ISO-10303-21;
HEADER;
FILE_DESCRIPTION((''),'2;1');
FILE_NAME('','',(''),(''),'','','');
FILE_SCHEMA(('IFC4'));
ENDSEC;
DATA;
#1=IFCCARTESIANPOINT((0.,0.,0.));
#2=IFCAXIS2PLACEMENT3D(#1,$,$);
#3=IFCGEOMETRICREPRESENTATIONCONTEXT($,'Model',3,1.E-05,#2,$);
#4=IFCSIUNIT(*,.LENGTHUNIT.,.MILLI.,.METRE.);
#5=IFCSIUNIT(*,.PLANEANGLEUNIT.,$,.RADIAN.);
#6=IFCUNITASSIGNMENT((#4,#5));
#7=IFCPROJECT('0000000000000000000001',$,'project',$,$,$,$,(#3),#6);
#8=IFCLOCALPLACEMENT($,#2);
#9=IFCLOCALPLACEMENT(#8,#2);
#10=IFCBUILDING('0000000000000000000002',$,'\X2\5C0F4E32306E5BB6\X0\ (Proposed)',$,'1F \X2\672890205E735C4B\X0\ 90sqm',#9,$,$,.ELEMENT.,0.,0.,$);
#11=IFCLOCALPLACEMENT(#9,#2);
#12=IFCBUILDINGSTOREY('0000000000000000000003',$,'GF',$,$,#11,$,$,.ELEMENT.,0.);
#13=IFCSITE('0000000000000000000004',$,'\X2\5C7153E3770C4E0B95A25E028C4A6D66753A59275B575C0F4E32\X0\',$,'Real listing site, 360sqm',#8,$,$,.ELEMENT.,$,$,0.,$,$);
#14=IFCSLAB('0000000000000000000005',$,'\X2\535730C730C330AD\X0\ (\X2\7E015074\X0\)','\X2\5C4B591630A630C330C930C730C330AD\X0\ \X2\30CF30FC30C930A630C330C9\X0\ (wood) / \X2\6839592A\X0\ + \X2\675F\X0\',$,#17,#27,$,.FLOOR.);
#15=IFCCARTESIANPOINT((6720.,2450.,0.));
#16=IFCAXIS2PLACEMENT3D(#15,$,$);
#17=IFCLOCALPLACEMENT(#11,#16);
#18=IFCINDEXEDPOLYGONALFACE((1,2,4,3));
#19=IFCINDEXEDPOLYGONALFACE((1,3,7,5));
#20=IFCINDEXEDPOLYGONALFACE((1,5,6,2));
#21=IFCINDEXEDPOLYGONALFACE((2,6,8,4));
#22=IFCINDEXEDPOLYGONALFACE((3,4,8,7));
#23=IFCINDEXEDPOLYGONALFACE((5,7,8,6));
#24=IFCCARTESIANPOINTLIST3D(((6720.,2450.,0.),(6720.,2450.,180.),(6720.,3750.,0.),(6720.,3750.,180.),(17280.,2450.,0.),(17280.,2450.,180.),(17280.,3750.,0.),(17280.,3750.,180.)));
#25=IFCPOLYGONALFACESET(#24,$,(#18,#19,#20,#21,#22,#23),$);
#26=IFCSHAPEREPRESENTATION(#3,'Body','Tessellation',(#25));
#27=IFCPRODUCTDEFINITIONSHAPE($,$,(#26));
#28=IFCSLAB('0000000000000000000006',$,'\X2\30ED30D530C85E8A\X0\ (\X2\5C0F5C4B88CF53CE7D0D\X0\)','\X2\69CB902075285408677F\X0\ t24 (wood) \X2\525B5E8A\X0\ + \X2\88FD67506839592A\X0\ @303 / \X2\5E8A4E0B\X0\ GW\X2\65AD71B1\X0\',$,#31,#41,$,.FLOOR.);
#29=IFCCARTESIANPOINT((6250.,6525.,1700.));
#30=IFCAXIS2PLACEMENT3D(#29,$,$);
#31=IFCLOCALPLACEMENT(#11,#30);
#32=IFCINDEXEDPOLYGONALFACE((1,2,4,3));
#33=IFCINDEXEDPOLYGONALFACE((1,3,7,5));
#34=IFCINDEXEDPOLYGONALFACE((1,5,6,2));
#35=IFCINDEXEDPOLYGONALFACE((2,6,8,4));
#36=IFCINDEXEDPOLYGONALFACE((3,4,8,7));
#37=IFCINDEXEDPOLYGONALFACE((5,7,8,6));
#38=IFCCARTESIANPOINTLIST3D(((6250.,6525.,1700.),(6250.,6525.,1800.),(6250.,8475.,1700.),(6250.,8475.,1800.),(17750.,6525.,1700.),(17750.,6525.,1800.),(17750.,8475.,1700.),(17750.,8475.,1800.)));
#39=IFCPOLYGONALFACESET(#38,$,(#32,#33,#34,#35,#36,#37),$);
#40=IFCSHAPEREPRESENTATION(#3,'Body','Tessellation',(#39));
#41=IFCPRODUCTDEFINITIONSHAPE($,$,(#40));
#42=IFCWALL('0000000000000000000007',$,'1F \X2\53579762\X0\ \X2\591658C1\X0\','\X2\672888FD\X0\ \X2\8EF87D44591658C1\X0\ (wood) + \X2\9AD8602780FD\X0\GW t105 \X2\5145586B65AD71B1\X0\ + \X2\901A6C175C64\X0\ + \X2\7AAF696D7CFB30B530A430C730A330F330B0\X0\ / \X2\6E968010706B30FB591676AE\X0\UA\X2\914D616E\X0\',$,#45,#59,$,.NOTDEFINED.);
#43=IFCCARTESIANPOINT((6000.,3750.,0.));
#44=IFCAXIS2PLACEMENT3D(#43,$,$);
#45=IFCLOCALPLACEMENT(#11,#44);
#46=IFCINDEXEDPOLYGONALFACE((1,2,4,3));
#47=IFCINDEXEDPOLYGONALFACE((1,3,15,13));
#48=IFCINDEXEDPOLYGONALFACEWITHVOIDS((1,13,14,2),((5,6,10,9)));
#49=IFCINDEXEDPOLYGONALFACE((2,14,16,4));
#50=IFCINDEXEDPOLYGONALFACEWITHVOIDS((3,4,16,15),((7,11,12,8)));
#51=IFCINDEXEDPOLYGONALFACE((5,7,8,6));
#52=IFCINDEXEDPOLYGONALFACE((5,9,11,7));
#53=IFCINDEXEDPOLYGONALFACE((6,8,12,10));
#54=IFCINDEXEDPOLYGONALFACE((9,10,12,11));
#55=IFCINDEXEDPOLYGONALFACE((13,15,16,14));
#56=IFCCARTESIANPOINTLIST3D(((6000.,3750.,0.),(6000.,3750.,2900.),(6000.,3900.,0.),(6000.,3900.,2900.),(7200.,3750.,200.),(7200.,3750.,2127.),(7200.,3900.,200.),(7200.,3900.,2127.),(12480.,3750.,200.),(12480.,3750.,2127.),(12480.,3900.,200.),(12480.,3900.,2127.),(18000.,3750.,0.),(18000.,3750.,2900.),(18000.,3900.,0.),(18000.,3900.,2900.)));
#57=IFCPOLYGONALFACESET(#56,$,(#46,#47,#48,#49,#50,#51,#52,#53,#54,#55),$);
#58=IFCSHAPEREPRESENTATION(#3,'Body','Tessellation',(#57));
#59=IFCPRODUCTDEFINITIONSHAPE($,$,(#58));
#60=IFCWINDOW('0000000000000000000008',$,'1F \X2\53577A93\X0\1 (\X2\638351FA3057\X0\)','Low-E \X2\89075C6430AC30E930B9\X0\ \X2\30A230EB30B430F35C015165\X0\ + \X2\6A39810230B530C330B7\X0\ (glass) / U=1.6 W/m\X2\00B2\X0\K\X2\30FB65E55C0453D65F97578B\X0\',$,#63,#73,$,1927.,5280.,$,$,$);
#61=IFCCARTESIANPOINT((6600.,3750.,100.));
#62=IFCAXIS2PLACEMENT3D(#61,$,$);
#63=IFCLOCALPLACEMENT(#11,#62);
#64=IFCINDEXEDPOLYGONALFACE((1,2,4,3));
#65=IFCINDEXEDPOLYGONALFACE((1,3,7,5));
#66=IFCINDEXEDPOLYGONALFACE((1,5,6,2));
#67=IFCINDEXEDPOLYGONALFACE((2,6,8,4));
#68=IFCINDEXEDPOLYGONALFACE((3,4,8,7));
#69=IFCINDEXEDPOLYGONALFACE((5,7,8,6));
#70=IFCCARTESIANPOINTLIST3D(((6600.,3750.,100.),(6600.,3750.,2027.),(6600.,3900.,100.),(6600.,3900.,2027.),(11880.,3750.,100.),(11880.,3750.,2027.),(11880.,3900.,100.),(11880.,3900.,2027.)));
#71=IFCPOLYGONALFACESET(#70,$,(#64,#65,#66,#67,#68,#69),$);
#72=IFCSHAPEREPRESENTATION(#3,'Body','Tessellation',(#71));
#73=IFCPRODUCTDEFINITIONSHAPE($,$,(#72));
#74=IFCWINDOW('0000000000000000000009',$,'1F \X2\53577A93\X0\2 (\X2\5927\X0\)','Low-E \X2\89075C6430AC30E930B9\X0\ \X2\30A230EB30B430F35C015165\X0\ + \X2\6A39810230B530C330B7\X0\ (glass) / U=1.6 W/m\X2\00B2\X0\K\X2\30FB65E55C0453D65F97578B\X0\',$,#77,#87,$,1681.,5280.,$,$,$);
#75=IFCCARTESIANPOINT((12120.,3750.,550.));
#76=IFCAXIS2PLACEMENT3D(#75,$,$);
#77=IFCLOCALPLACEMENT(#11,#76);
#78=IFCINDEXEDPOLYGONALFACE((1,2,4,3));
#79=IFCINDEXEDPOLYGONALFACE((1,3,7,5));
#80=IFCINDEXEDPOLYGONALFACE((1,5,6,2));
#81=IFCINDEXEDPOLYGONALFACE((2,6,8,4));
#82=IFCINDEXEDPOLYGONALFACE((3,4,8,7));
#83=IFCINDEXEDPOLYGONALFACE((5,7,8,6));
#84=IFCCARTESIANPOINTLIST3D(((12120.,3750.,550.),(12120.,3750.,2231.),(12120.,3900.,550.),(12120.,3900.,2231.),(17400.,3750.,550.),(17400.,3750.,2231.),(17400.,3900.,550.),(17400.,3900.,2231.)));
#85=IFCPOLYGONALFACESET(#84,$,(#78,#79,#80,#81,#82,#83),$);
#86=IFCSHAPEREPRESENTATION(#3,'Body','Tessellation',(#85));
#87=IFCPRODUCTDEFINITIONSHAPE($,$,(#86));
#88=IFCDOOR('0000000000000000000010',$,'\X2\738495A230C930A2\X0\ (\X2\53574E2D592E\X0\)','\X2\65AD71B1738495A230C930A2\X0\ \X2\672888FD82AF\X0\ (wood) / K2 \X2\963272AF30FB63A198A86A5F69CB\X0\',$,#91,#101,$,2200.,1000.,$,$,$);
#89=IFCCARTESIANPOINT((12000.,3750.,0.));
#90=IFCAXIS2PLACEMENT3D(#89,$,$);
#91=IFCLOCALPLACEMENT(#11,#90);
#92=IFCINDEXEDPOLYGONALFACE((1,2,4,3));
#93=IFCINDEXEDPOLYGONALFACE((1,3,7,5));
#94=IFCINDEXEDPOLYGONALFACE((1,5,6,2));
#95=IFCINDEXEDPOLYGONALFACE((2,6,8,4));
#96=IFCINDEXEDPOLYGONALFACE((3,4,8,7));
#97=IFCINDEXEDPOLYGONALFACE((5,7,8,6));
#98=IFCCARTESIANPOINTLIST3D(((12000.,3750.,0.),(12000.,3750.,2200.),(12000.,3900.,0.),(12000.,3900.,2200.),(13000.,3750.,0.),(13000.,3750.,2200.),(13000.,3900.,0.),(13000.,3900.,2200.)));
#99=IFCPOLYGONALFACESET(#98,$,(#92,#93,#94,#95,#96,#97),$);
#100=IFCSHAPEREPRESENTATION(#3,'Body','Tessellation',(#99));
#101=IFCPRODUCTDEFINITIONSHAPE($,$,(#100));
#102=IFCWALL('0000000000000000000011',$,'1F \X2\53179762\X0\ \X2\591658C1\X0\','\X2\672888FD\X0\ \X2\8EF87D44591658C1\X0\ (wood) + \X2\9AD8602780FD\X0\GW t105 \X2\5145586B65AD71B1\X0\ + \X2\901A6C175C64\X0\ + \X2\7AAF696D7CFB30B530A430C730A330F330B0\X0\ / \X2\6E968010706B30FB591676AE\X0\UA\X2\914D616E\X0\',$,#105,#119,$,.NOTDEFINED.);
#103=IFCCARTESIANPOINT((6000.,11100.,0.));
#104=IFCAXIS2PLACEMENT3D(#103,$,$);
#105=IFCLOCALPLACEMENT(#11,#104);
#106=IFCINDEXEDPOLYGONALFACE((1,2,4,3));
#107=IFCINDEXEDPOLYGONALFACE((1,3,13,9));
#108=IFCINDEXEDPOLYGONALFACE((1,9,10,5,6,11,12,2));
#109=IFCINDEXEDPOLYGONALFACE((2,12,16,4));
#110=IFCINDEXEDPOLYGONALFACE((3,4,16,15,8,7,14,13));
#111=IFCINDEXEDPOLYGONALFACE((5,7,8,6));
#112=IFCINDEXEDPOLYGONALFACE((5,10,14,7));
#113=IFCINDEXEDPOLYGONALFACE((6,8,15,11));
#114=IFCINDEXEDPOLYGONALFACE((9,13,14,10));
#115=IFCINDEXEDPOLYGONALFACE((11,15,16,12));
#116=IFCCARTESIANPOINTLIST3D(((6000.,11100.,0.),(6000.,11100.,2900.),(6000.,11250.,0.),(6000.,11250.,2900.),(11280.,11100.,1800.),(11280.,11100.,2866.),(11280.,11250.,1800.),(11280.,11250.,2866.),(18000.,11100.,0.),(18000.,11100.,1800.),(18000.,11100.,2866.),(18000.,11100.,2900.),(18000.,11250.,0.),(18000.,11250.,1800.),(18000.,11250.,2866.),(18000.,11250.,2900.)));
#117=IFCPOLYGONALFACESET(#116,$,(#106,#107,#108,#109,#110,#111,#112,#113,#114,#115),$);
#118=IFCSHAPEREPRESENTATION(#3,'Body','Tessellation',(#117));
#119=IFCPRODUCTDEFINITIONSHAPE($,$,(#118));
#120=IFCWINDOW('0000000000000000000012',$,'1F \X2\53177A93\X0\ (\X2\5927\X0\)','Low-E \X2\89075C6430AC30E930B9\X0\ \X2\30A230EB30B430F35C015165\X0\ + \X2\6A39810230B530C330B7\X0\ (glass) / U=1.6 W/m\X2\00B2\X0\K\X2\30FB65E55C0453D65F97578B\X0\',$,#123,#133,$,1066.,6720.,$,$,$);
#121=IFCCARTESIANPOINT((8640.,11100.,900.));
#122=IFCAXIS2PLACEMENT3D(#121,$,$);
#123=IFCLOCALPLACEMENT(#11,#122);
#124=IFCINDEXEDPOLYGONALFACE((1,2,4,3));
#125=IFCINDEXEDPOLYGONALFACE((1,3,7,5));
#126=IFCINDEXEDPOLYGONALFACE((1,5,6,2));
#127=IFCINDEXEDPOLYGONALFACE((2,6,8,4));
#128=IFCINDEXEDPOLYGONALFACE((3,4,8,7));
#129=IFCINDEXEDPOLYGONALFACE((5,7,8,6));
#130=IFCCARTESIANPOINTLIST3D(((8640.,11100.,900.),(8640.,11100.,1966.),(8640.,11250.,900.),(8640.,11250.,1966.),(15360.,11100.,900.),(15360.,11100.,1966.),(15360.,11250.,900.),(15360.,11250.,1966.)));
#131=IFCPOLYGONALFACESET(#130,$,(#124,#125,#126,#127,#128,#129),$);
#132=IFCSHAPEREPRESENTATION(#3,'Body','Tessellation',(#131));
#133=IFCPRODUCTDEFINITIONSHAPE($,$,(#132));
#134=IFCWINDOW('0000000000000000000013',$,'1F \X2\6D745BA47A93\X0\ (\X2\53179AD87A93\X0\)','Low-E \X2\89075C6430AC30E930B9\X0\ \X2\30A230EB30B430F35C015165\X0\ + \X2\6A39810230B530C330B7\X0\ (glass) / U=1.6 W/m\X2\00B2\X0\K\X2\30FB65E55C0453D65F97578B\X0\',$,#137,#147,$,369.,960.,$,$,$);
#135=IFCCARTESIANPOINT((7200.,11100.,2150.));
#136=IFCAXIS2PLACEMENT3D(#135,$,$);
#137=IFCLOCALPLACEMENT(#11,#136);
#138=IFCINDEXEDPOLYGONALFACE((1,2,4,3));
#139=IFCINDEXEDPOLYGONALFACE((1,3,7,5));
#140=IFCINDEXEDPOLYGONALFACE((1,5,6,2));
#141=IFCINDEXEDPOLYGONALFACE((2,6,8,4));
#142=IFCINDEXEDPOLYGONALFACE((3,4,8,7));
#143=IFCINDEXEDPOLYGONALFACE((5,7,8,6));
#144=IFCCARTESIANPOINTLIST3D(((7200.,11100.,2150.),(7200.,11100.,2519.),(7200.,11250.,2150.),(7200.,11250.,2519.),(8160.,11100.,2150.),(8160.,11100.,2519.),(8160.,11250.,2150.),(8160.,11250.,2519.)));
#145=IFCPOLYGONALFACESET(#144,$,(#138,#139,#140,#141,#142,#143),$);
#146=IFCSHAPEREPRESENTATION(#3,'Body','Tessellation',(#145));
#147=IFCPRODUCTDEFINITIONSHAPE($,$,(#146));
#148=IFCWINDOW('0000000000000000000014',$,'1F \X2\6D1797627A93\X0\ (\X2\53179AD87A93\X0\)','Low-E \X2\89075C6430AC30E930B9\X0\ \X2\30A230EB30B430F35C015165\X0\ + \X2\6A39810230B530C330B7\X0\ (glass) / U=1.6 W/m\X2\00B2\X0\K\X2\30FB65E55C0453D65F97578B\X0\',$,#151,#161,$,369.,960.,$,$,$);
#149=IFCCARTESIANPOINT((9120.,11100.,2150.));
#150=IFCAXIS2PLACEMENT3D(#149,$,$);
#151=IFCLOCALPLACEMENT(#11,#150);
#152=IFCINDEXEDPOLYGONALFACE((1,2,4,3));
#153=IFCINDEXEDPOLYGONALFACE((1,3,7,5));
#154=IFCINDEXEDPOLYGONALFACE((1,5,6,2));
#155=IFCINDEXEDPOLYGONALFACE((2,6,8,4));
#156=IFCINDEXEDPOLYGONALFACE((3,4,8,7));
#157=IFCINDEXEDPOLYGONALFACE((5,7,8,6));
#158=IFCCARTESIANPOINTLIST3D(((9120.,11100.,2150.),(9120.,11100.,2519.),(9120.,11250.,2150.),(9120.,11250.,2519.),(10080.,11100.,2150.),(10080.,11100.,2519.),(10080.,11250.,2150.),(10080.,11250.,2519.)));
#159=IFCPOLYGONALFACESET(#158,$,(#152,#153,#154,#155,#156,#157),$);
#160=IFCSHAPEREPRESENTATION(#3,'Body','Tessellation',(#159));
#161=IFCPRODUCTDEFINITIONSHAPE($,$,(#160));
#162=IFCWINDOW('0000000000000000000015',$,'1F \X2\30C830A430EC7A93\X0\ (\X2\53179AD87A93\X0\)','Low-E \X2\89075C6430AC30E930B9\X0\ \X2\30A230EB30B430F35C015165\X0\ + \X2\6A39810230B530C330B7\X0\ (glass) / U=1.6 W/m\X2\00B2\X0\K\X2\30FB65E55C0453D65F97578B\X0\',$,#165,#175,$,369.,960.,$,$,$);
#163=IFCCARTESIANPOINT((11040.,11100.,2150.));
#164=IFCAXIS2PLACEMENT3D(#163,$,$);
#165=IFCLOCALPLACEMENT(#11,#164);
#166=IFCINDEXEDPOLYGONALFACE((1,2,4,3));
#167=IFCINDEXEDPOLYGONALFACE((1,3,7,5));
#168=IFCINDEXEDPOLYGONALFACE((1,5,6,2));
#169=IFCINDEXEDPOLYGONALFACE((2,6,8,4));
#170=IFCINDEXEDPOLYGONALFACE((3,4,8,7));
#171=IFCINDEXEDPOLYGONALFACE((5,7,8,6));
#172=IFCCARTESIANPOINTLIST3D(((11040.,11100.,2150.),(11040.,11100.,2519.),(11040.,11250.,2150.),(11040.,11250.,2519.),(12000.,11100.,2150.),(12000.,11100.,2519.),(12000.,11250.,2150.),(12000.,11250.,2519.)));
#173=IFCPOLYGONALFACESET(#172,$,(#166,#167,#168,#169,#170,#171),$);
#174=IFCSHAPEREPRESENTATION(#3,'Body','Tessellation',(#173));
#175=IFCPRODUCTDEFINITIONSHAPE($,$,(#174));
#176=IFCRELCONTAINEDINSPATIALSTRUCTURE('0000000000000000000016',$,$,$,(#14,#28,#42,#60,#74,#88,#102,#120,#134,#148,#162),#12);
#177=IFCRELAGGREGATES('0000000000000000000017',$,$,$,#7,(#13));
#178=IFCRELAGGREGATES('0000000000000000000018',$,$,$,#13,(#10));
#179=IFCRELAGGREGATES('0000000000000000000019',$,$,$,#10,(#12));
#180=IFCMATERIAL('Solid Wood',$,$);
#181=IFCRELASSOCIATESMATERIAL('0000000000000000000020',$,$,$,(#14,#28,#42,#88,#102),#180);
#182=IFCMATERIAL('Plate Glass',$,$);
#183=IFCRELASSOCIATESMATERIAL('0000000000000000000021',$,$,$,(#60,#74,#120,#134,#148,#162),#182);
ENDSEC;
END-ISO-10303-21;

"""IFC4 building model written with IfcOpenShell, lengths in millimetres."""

from ifc_helpers import new_model, si_unit, frame, frame_2d, origin, place, context, project, spatial, rectangle, extrude, material, element, fill, save


model = new_model("IFC4")

# Units and contexts
model_context = context("Model", 3, precision=1e-05, world=origin())
ifc_project = project(units=[si_unit("LENGTHUNIT", "METRE", prefix="MILLI"), si_unit("PLANEANGLEUNIT", "RADIAN")], contexts=[model_context])

# Site, building, storey
site_placement = place(None, origin())
site = spatial("IfcSite", under=ifc_project, at=site_placement, Name="山口県下関市豊浦町大字小串", ObjectType="Real listing site, 360sqm", CompositionType="ELEMENT", RefElevation=0.0)
building_placement = place(site_placement, origin())
building = spatial("IfcBuilding", under=site, at=building_placement, Name="小串の家 (Proposed)", ObjectType="1F 木造平屋 90sqm", CompositionType="ELEMENT", ElevationOfRefHeight=0.0, ElevationOfTerrain=0.0)
storey_placement = place(building_placement, origin())
storey = spatial("IfcBuildingStorey", under=building, at=storey_placement, Name="GF", CompositionType="ELEMENT", Elevation=0.0)

# Slabs
ifc_material_1 = material(Name="Solid Wood")
slab_1_placement = place(storey_placement, frame((6720.0, 2450.0, 0.0)))
element("IfcSlab", 1, at=slab_1_placement, inside=storey, material=ifc_material_1, Name="南デッキ (縁側)", Description="屋外ウッドデッキ ハードウッド (wood) / 根太 + 束", PredefinedType="FLOOR", context=model_context, shape_type="SweptSolid", body=[
    extrude(rectangle(XDim=10560.0, YDim=1300.0, at=frame_2d((5280.0, 650.0))), frame((6720.0, 2450.0, 0.0)), (0.0, 0.0, 1.0), 180.0),
])
slab_2_placement = place(storey_placement, frame((6250.0, 6525.0, 1700.0)))
element("IfcSlab", 2, at=slab_2_placement, inside=storey, material=ifc_material_1, Name="ロフト床 (小屋裏収納)", Description="構造用合板 t24 (wood) 剛床 + 製材根太 @303 / 床下 GW断熱", PredefinedType="FLOOR", context=model_context, shape_type="SweptSolid", body=[
    extrude(rectangle(XDim=11500.0, YDim=1950.0, at=frame_2d((5750.0, 975.0))), frame((6250.0, 6525.0, 1700.0)), (0.0, 0.0, 1.0), 100.0),
])

# Wall, openings, windows, door
wall_1_placement = place(storey_placement, frame((6000.0, 3750.0, 0.0)))
wall_1 = element("IfcWall", 3, at=wall_1_placement, inside=storey, material=ifc_material_1, Name="1F 南面 外壁", Description="木製 軸組外壁 (wood) + 高性能GW t105 充填断熱 + 通気層 + 窯業系サイディング / 準耐火・外皮UA配慮", PredefinedType="NOTDEFINED", context=model_context, shape_type="SweptSolid", body=[
    extrude(rectangle(XDim=12000.0, YDim=150.0, at=frame_2d((6000.0, 75.0))), frame((6000.0, 3750.0, 0.0)), (0.0, 0.0, 1.0), 2900.0),
])
opening_1_placement = place(storey_placement, frame((6600.0, 3750.0, 100.0)))
opening_1 = element("IfcOpeningElement", 4, at=opening_1_placement, cuts=wall_1, PredefinedType="NOTDEFINED", context=model_context, shape_type="SweptSolid", body=[
    extrude(rectangle(XDim=5280.0, YDim=150.0, at=frame_2d((2640.0, 75.0))), frame((6600.0, 3750.0, 100.0)), (0.0, 0.0, 1.0), 1927.0),
])
opening_2_placement = place(storey_placement, frame((12120.0, 3750.0, 550.0)))
opening_2 = element("IfcOpeningElement", 5, at=opening_2_placement, cuts=wall_1, PredefinedType="NOTDEFINED", context=model_context, shape_type="SweptSolid", body=[
    extrude(rectangle(XDim=5280.0, YDim=150.0, at=frame_2d((2640.0, 75.0))), frame((12120.0, 3750.0, 550.0)), (0.0, 0.0, 1.0), 1681.0),
])
opening_3_placement = place(storey_placement, frame((12000.0, 3750.0, 0.0)))
opening_3 = element("IfcOpeningElement", 6, at=opening_3_placement, cuts=wall_1, PredefinedType="NOTDEFINED", context=model_context, shape_type="SweptSolid", body=[
    extrude(rectangle(XDim=1000.0, YDim=150.0, at=frame_2d((500.0, 75.0))), frame((12000.0, 3750.0, 0.0)), (0.0, 0.0, 1.0), 2200.0),
])
ifc_material_2 = material(Name="Plate Glass")
window_1_placement = place(storey_placement, frame((6600.0, 3750.0, 100.0)))
window_1 = element("IfcWindow", 7, at=window_1_placement, inside=storey, material=ifc_material_2, Name="1F 南窓1 (掃出し)", Description="Low-E 複層ガラス アルゴン封入 + 樹脂サッシ (glass) / U=1.6 W/m²K・日射取得型", OverallHeight=1927.0, OverallWidth=5280.0, context=model_context, shape_type="SweptSolid", body=[
    extrude(rectangle(XDim=5280.0, YDim=150.0, at=frame_2d((2640.0, 75.0))), frame((6600.0, 3750.0, 100.0)), (0.0, 0.0, 1.0), 1927.0),
])
fill(opening_1, window_1)
window_2_placement = place(storey_placement, frame((12120.0, 3750.0, 550.0)))
window_2 = element("IfcWindow", 8, at=window_2_placement, inside=storey, material=ifc_material_2, Name="1F 南窓2 (大)", Description="Low-E 複層ガラス アルゴン封入 + 樹脂サッシ (glass) / U=1.6 W/m²K・日射取得型", OverallHeight=1681.0, OverallWidth=5280.0, context=model_context, shape_type="SweptSolid", body=[
    extrude(rectangle(XDim=5280.0, YDim=150.0, at=frame_2d((2640.0, 75.0))), frame((12120.0, 3750.0, 550.0)), (0.0, 0.0, 1.0), 1681.0),
])
fill(opening_2, window_2)
door_1_placement = place(storey_placement, frame((12000.0, 3750.0, 0.0)))
door_1 = element("IfcDoor", 9, at=door_1_placement, inside=storey, material=ifc_material_1, Name="玄関ドア (南中央)", Description="断熱玄関ドア 木製芯 (wood) / K2 防犯・採風機構", OverallHeight=2200.0, OverallWidth=1000.0, context=model_context, shape_type="SweptSolid", body=[
    extrude(rectangle(XDim=1000.0, YDim=150.0, at=frame_2d((500.0, 75.0))), frame((12000.0, 3750.0, 0.0)), (0.0, 0.0, 1.0), 2200.0),
])
fill(opening_3, door_1)

# Wall, openings, windows
wall_2_placement = place(storey_placement, frame((6000.0, 11100.0, 0.0)))
wall_2 = element("IfcWall", 10, at=wall_2_placement, inside=storey, material=ifc_material_1, Name="1F 北面 外壁", Description="木製 軸組外壁 (wood) + 高性能GW t105 充填断熱 + 通気層 + 窯業系サイディング / 準耐火・外皮UA配慮", PredefinedType="NOTDEFINED", context=model_context, shape_type="SweptSolid", body=[
    extrude(rectangle(XDim=12000.0, YDim=150.0, at=frame_2d((6000.0, 75.0))), frame((6000.0, 11100.0, 0.0)), (0.0, 0.0, 1.0), 2900.0),
])
opening_4_placement = place(storey_placement, frame((8640.0, 11100.0, 900.0)))
opening_4 = element("IfcOpeningElement", 11, at=opening_4_placement, cuts=wall_2, PredefinedType="NOTDEFINED", context=model_context, shape_type="SweptSolid", body=[
    extrude(rectangle(XDim=6720.0, YDim=150.0, at=frame_2d((3360.0, 75.0))), frame((8640.0, 11100.0, 900.0)), (0.0, 0.0, 1.0), 1066.0),
])
opening_5_placement = place(storey_placement, frame((7200.0, 11100.0, 2150.0)))
opening_5 = element("IfcOpeningElement", 12, at=opening_5_placement, cuts=wall_2, PredefinedType="NOTDEFINED", context=model_context, shape_type="SweptSolid", body=[
    extrude(rectangle(XDim=960.0, YDim=150.0, at=frame_2d((480.0, 75.0))), frame((7200.0, 11100.0, 2150.0)), (0.0, 0.0, 1.0), 369.0),
])
opening_6_placement = place(storey_placement, frame((9120.0, 11100.0, 2150.0)))
opening_6 = element("IfcOpeningElement", 13, at=opening_6_placement, cuts=wall_2, PredefinedType="NOTDEFINED", context=model_context, shape_type="SweptSolid", body=[
    extrude(rectangle(XDim=960.0, YDim=150.0, at=frame_2d((480.0, 75.0))), frame((9120.0, 11100.0, 2150.0)), (0.0, 0.0, 1.0), 369.0),
])
opening_7_placement = place(storey_placement, frame((11040.0, 11100.0, 2150.0)))
opening_7 = element("IfcOpeningElement", 14, at=opening_7_placement, cuts=wall_2, PredefinedType="NOTDEFINED", context=model_context, shape_type="SweptSolid", body=[
    extrude(rectangle(XDim=960.0, YDim=150.0, at=frame_2d((480.0, 75.0))), frame((11040.0, 11100.0, 2150.0)), (0.0, 0.0, 1.0), 369.0),
])
window_3_placement = place(storey_placement, frame((8640.0, 11100.0, 900.0)))
window_3 = element("IfcWindow", 15, at=window_3_placement, inside=storey, material=ifc_material_2, Name="1F 北窓 (大)", Description="Low-E 複層ガラス アルゴン封入 + 樹脂サッシ (glass) / U=1.6 W/m²K・日射取得型", OverallHeight=1066.0, OverallWidth=6720.0, context=model_context, shape_type="SweptSolid", body=[
    extrude(rectangle(XDim=6720.0, YDim=150.0, at=frame_2d((3360.0, 75.0))), frame((8640.0, 11100.0, 900.0)), (0.0, 0.0, 1.0), 1066.0),
])
fill(opening_4, window_3)
window_4_placement = place(storey_placement, frame((7200.0, 11100.0, 2150.0)))
window_4 = element("IfcWindow", 16, at=window_4_placement, inside=storey, material=ifc_material_2, Name="1F 浴室窓 (北高窓)", Description="Low-E 複層ガラス アルゴン封入 + 樹脂サッシ (glass) / U=1.6 W/m²K・日射取得型", OverallHeight=369.0, OverallWidth=960.0, context=model_context, shape_type="SweptSolid", body=[
    extrude(rectangle(XDim=960.0, YDim=150.0, at=frame_2d((480.0, 75.0))), frame((7200.0, 11100.0, 2150.0)), (0.0, 0.0, 1.0), 369.0),
])
fill(opening_5, window_4)
window_5_placement = place(storey_placement, frame((9120.0, 11100.0, 2150.0)))
window_5 = element("IfcWindow", 17, at=window_5_placement, inside=storey, material=ifc_material_2, Name="1F 洗面窓 (北高窓)", Description="Low-E 複層ガラス アルゴン封入 + 樹脂サッシ (glass) / U=1.6 W/m²K・日射取得型", OverallHeight=369.0, OverallWidth=960.0, context=model_context, shape_type="SweptSolid", body=[
    extrude(rectangle(XDim=960.0, YDim=150.0, at=frame_2d((480.0, 75.0))), frame((9120.0, 11100.0, 2150.0)), (0.0, 0.0, 1.0), 369.0),
])
fill(opening_6, window_5)
window_6_placement = place(storey_placement, frame((11040.0, 11100.0, 2150.0)))
window_6 = element("IfcWindow", 18, at=window_6_placement, inside=storey, material=ifc_material_2, Name="1F トイレ窓 (北高窓)", Description="Low-E 複層ガラス アルゴン封入 + 樹脂サッシ (glass) / U=1.6 W/m²K・日射取得型", OverallHeight=369.0, OverallWidth=960.0, context=model_context, shape_type="SweptSolid", body=[
    extrude(rectangle(XDim=960.0, YDim=150.0, at=frame_2d((480.0, 75.0))), frame((11040.0, 11100.0, 2150.0)), (0.0, 0.0, 1.0), 369.0),
])
fill(opening_7, window_6)

save(model, "model.ifc")
